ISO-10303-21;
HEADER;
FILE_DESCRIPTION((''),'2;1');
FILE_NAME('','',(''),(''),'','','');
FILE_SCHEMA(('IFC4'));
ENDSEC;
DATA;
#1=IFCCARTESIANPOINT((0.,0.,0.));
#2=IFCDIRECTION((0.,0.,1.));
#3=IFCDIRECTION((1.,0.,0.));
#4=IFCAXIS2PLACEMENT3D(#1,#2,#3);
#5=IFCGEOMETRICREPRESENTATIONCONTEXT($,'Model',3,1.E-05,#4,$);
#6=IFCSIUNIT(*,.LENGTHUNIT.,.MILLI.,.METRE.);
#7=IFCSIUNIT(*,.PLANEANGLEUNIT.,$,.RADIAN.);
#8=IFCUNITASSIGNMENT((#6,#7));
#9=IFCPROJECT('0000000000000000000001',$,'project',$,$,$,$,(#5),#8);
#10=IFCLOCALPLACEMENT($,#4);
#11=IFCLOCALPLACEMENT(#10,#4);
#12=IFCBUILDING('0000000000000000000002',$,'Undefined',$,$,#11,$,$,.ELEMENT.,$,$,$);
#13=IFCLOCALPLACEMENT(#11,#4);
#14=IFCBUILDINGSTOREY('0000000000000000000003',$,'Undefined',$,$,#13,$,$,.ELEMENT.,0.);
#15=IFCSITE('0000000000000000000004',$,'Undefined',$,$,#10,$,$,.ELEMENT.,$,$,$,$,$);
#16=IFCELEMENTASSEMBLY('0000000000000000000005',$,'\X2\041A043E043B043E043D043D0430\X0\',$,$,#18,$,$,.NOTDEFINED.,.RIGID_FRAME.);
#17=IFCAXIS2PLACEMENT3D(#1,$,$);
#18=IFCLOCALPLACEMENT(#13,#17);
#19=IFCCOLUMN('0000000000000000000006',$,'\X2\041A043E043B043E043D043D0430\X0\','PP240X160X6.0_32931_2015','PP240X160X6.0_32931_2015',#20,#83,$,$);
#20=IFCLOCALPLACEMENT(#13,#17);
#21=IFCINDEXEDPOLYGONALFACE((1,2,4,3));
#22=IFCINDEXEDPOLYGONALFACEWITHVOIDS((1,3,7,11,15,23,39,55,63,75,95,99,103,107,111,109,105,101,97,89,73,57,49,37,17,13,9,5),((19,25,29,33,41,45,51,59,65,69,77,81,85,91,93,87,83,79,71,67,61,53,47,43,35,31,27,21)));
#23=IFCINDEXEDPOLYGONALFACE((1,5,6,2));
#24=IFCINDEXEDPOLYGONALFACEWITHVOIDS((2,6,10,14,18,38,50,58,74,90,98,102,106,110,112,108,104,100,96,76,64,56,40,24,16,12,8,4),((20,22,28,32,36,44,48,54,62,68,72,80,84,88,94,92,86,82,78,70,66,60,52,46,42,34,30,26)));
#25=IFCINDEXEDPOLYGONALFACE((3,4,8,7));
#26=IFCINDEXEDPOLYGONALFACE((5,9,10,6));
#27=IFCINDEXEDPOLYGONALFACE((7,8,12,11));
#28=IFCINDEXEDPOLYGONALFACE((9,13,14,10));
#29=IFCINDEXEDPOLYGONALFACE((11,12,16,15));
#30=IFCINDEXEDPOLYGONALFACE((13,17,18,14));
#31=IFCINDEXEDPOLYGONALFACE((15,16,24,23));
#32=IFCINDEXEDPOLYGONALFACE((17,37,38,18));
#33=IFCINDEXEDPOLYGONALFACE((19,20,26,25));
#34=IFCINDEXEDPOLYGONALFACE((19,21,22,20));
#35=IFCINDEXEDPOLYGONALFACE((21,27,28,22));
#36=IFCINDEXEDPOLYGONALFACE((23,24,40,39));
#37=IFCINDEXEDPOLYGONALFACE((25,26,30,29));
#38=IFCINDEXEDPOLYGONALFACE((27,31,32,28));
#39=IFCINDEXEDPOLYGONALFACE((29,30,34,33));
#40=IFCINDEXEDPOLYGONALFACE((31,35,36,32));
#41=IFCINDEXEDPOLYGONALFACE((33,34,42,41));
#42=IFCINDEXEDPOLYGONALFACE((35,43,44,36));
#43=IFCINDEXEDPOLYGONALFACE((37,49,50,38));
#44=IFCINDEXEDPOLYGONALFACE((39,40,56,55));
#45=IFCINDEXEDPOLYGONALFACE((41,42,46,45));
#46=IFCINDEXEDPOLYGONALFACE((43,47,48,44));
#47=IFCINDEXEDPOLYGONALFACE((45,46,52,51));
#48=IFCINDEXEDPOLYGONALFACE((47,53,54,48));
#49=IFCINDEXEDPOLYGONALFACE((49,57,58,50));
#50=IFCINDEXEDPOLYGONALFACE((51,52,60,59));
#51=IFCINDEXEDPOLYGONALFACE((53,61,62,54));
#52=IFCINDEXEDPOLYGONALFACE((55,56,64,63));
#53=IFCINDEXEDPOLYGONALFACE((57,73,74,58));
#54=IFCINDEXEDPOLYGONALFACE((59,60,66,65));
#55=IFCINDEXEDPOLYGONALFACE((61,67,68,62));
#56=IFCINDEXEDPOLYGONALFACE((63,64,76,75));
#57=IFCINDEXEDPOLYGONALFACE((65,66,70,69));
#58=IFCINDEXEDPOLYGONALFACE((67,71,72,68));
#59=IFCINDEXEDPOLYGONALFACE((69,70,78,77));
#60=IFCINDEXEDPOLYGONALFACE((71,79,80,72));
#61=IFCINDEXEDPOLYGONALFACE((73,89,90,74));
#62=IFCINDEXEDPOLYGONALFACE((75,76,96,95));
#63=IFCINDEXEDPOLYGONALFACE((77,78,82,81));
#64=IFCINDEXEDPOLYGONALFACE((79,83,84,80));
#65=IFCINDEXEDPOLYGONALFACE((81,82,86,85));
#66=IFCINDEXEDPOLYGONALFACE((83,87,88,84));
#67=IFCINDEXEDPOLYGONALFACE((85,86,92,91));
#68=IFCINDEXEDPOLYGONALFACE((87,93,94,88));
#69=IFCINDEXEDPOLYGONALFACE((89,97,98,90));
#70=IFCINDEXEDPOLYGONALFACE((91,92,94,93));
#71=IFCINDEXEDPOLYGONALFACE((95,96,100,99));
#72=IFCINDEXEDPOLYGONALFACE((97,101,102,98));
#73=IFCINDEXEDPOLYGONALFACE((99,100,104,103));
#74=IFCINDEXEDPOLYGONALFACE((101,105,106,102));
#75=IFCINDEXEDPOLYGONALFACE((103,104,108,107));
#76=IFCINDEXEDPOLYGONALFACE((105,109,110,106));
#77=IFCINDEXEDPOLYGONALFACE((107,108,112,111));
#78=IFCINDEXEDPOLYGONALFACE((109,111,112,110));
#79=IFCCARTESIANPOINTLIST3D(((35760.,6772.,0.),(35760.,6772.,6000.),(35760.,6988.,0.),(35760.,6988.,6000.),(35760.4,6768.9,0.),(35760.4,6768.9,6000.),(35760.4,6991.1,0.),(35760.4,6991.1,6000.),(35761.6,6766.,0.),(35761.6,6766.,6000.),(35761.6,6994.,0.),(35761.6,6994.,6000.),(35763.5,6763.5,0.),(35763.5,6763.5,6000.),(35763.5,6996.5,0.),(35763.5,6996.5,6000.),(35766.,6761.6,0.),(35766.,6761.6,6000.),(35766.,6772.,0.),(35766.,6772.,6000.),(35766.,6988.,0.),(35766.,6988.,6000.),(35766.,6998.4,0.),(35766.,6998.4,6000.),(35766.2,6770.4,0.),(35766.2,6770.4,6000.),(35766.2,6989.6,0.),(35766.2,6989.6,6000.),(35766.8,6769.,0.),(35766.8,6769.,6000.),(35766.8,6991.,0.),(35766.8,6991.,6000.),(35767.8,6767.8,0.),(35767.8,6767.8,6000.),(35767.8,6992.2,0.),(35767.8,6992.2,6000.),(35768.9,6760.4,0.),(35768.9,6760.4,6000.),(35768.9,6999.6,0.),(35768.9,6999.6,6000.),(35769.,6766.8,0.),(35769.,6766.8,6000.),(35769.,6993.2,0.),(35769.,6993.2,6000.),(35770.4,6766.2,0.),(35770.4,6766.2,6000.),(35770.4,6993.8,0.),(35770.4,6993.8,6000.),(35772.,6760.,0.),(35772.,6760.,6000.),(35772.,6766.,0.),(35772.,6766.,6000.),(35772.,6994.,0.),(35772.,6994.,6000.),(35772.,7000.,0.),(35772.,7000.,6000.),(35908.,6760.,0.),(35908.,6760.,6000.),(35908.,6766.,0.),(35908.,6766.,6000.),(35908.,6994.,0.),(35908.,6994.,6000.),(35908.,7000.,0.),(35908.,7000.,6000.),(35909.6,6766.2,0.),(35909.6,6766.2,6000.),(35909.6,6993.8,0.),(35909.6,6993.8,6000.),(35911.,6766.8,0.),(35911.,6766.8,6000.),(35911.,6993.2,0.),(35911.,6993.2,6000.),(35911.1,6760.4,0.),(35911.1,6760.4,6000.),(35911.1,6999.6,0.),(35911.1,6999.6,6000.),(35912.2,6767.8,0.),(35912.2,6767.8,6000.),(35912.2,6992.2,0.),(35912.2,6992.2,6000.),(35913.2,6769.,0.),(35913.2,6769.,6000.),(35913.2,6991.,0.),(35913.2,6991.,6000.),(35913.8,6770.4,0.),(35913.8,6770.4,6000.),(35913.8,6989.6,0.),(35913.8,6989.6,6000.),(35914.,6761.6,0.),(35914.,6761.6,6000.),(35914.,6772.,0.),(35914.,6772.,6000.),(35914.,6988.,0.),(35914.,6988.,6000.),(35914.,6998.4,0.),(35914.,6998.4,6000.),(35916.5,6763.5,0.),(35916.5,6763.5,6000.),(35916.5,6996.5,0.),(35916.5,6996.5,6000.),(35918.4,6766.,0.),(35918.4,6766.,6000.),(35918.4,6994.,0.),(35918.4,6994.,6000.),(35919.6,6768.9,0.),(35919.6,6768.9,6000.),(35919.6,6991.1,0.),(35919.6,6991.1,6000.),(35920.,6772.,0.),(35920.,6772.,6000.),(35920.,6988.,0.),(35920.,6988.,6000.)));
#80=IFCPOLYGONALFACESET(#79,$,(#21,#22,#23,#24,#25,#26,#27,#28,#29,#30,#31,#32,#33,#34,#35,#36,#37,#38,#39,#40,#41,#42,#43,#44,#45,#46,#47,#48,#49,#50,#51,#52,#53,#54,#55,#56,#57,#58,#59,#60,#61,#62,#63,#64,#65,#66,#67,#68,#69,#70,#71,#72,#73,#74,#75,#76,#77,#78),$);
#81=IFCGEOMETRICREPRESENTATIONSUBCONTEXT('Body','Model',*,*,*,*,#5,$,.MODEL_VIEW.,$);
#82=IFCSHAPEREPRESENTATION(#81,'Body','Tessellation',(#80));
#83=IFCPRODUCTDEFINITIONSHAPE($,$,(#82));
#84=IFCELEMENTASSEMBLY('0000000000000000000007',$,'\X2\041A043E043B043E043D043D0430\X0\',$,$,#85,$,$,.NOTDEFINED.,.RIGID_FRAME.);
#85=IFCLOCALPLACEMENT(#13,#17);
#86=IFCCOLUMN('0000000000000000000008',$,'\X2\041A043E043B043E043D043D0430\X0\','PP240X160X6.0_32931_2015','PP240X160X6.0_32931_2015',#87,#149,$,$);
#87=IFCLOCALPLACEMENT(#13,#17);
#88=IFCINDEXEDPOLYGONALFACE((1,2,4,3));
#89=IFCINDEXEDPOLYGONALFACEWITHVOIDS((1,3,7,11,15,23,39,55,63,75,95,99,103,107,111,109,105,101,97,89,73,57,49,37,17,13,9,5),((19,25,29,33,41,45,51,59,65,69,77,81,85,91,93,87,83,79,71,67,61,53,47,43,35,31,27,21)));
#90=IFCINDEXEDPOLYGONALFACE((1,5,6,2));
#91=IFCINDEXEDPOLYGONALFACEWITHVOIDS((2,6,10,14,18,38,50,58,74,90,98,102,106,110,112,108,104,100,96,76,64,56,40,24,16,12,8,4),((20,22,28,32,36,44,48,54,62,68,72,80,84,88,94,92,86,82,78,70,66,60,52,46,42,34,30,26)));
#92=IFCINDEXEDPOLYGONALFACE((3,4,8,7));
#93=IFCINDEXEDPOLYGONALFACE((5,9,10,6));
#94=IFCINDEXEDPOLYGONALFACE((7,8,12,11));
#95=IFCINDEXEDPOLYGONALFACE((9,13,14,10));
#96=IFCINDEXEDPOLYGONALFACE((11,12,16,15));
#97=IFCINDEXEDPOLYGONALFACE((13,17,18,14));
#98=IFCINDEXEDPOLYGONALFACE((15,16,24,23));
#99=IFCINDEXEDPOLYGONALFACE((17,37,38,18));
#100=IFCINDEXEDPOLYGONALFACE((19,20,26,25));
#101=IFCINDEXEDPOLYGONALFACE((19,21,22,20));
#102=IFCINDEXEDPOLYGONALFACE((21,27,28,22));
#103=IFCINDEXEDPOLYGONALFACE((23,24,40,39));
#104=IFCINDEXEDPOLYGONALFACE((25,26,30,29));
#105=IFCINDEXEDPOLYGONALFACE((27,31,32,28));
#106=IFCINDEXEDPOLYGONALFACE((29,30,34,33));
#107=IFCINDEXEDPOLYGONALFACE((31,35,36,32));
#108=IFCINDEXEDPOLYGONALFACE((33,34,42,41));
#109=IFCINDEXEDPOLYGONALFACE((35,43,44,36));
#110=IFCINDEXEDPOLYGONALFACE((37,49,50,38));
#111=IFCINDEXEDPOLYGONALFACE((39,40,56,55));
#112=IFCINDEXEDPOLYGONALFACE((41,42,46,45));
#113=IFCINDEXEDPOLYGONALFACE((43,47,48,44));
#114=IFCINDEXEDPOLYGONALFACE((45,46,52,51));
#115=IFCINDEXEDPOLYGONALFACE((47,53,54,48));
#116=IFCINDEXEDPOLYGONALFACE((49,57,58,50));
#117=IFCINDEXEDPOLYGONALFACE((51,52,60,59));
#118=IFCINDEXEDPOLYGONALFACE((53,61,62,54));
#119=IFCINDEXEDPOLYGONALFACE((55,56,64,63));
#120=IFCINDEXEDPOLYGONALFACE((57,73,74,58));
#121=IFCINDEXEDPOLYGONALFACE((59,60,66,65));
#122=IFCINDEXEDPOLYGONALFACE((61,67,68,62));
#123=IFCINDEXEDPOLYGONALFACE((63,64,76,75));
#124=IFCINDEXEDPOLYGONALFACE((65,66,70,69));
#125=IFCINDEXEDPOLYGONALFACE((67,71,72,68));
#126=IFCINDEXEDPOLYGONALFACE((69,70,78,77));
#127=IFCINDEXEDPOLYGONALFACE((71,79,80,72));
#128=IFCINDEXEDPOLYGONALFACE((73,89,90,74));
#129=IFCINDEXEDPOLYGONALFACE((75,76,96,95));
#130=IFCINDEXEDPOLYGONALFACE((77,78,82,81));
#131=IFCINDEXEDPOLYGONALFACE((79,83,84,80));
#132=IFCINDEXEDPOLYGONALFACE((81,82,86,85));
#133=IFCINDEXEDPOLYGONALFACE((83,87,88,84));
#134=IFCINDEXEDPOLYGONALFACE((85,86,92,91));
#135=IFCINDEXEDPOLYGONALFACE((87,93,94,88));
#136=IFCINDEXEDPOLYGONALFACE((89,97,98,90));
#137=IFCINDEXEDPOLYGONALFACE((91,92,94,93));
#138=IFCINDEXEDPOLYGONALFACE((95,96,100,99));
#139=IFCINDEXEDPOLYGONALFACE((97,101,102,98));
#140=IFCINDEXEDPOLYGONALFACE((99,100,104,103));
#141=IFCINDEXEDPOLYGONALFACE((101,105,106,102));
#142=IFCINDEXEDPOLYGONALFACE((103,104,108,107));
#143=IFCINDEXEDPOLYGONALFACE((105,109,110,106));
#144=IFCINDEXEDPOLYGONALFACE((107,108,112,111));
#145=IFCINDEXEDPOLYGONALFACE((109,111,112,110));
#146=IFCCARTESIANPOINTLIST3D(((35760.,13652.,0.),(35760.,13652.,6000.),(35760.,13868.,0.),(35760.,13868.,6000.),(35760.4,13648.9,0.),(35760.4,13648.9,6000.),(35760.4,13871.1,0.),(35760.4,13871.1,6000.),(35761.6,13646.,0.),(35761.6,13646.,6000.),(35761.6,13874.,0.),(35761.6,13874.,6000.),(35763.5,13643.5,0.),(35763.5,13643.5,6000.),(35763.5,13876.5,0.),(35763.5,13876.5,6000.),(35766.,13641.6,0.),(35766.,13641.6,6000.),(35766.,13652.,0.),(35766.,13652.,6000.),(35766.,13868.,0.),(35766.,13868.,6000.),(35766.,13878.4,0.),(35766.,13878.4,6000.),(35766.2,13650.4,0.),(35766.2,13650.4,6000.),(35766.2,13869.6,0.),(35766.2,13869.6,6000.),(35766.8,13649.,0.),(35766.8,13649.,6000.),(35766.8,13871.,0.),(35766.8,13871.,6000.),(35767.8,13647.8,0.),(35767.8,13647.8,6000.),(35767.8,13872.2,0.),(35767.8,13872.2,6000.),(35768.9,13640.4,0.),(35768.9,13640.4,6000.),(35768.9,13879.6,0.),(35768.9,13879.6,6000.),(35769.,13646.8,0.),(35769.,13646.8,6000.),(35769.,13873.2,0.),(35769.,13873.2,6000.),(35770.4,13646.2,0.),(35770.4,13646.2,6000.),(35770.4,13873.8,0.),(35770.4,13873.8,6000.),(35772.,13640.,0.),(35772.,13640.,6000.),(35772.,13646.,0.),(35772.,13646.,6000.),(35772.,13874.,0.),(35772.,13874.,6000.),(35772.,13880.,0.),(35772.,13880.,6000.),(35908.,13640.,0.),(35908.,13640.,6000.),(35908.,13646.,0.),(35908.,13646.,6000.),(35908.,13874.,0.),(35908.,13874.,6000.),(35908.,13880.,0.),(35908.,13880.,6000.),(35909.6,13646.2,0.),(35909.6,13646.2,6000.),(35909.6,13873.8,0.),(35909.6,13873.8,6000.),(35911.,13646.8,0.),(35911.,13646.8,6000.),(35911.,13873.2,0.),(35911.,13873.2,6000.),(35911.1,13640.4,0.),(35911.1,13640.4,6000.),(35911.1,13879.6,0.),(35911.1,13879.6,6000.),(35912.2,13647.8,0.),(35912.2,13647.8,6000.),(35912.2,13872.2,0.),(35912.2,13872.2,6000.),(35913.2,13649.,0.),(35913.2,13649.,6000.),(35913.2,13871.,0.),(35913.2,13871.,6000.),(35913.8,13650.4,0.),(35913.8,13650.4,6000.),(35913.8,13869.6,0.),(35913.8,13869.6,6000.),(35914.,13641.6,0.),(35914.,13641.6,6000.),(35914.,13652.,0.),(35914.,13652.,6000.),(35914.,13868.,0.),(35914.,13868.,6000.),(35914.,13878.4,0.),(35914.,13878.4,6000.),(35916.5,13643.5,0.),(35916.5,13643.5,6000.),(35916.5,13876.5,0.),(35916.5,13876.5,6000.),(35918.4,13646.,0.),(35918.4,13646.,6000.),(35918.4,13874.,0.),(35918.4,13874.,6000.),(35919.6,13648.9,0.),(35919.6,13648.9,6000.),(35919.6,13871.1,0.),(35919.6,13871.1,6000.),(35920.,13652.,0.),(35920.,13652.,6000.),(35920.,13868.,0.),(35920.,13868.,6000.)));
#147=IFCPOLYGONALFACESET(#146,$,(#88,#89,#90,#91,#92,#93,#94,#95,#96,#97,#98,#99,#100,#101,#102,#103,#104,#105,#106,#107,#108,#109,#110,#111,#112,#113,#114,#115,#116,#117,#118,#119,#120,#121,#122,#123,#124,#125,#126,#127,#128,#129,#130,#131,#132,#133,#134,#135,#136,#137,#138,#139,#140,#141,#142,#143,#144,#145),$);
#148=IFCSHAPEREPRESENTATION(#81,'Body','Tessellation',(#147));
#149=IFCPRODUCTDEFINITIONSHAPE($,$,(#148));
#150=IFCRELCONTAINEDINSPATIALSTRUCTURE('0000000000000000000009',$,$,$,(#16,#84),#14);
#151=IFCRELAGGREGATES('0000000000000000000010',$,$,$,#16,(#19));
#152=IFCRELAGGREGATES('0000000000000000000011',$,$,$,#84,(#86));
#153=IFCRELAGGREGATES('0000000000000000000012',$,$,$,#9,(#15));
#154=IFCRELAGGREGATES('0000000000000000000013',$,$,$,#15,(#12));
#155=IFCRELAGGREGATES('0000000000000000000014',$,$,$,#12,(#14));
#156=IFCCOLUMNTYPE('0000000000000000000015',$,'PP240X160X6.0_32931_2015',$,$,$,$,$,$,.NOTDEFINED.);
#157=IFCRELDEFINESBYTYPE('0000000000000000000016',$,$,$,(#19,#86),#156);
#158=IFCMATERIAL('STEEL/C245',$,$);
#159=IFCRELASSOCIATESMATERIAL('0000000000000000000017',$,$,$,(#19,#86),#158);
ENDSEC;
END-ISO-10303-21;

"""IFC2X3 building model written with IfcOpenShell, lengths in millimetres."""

from ifc_helpers import new_model, si_unit, frame, origin_with_axes, origin_2d_with_axis, place, context, subcontext, project, spatial, hollow_rectangle, extrude, material, type_object, element, aggregate, save


model = new_model("IFC2X3")

# Units and contexts
model_context = context("Model", 3, precision=1e-05, world=origin_with_axes())
body_context = subcontext(model_context, "Body", "Model", "MODEL_VIEW")
ifc_project = project(units=[si_unit("LENGTHUNIT", "METRE", prefix="MILLI"), si_unit("PLANEANGLEUNIT", "RADIAN")], contexts=[model_context])

# Site, building, storey
site_placement = place(None, origin_with_axes())
site = spatial("IfcSite", under=ifc_project, at=site_placement, Name="Undefined", CompositionType="ELEMENT")
building_placement = place(site_placement, origin_with_axes())
building = spatial("IfcBuilding", under=site, at=building_placement, Name="Undefined", CompositionType="ELEMENT")
storey_placement = place(building_placement, origin_with_axes())
storey = spatial("IfcBuildingStorey", under=building, at=storey_placement, Name="Undefined", CompositionType="ELEMENT", Elevation=0.0)

# Element assemblies, columns
assembly_1_placement = place(storey_placement, origin_with_axes())
assembly_1 = element("IfcElementAssembly", 1, at=assembly_1_placement, inside=storey, Name="Колонна", AssemblyPlace="NOTDEFINED", PredefinedType="RIGID_FRAME")
ifc_material = material(Name="STEEL/C245")
column_type_1 = type_object("IfcColumnType", Name="PP240X160X6.0_32931_2015", PredefinedType="NOTDEFINED")
column_1_placement = place(assembly_1_placement, frame((35840.0, 6880.0, 0.0), z_axis=(0.0, 0.0, 1.0), x_axis=(0.0, 1.0, 0.0)))
column_1 = element("IfcColumn", 2, at=column_1_placement, type_object=column_type_1, material=ifc_material, Name="Колонна", Description="PP240X160X6.0_32931_2015", ObjectType="PP240X160X6.0_32931_2015", context=body_context, shape_type="SweptSolid", body=[
    extrude(hollow_rectangle(XDim=160.0, YDim=240.0, WallThickness=6.0, InnerFilletRadius=6.0, OuterFilletRadius=12.0, at=origin_2d_with_axis()), frame((0.0, 0.0, 6000.0), z_axis=(0.0, 0.0, -1.0), x_axis=(0.0, 1.0, 0.0)), (0.0, 0.0, 1.0), 6000.0),
])
aggregate(assembly_1, [column_1])
assembly_2_placement = place(storey_placement, origin_with_axes())
assembly_2 = element("IfcElementAssembly", 3, at=assembly_2_placement, inside=storey, Name="Колонна", AssemblyPlace="NOTDEFINED", PredefinedType="RIGID_FRAME")
column_2_placement = place(assembly_2_placement, frame((35840.0, 13760.0, 0.0), z_axis=(0.0, 0.0, 1.0), x_axis=(0.0, 1.0, 0.0)))
column_2 = element("IfcColumn", 4, at=column_2_placement, type_object=column_type_1, material=ifc_material, Name="Колонна", Description="PP240X160X6.0_32931_2015", ObjectType="PP240X160X6.0_32931_2015", context=body_context, shape_type="SweptSolid", body=[
    extrude(hollow_rectangle(XDim=160.0, YDim=240.0, WallThickness=6.0, InnerFilletRadius=6.0, OuterFilletRadius=12.0, at=origin_2d_with_axis()), frame((0.0, 0.0, 6000.0), z_axis=(0.0, 0.0, -1.0), x_axis=(0.0, 1.0, 0.0)), (0.0, 0.0, 1.0), 6000.0),
])
aggregate(assembly_2, [column_2])

save(model, "model.ifc")
